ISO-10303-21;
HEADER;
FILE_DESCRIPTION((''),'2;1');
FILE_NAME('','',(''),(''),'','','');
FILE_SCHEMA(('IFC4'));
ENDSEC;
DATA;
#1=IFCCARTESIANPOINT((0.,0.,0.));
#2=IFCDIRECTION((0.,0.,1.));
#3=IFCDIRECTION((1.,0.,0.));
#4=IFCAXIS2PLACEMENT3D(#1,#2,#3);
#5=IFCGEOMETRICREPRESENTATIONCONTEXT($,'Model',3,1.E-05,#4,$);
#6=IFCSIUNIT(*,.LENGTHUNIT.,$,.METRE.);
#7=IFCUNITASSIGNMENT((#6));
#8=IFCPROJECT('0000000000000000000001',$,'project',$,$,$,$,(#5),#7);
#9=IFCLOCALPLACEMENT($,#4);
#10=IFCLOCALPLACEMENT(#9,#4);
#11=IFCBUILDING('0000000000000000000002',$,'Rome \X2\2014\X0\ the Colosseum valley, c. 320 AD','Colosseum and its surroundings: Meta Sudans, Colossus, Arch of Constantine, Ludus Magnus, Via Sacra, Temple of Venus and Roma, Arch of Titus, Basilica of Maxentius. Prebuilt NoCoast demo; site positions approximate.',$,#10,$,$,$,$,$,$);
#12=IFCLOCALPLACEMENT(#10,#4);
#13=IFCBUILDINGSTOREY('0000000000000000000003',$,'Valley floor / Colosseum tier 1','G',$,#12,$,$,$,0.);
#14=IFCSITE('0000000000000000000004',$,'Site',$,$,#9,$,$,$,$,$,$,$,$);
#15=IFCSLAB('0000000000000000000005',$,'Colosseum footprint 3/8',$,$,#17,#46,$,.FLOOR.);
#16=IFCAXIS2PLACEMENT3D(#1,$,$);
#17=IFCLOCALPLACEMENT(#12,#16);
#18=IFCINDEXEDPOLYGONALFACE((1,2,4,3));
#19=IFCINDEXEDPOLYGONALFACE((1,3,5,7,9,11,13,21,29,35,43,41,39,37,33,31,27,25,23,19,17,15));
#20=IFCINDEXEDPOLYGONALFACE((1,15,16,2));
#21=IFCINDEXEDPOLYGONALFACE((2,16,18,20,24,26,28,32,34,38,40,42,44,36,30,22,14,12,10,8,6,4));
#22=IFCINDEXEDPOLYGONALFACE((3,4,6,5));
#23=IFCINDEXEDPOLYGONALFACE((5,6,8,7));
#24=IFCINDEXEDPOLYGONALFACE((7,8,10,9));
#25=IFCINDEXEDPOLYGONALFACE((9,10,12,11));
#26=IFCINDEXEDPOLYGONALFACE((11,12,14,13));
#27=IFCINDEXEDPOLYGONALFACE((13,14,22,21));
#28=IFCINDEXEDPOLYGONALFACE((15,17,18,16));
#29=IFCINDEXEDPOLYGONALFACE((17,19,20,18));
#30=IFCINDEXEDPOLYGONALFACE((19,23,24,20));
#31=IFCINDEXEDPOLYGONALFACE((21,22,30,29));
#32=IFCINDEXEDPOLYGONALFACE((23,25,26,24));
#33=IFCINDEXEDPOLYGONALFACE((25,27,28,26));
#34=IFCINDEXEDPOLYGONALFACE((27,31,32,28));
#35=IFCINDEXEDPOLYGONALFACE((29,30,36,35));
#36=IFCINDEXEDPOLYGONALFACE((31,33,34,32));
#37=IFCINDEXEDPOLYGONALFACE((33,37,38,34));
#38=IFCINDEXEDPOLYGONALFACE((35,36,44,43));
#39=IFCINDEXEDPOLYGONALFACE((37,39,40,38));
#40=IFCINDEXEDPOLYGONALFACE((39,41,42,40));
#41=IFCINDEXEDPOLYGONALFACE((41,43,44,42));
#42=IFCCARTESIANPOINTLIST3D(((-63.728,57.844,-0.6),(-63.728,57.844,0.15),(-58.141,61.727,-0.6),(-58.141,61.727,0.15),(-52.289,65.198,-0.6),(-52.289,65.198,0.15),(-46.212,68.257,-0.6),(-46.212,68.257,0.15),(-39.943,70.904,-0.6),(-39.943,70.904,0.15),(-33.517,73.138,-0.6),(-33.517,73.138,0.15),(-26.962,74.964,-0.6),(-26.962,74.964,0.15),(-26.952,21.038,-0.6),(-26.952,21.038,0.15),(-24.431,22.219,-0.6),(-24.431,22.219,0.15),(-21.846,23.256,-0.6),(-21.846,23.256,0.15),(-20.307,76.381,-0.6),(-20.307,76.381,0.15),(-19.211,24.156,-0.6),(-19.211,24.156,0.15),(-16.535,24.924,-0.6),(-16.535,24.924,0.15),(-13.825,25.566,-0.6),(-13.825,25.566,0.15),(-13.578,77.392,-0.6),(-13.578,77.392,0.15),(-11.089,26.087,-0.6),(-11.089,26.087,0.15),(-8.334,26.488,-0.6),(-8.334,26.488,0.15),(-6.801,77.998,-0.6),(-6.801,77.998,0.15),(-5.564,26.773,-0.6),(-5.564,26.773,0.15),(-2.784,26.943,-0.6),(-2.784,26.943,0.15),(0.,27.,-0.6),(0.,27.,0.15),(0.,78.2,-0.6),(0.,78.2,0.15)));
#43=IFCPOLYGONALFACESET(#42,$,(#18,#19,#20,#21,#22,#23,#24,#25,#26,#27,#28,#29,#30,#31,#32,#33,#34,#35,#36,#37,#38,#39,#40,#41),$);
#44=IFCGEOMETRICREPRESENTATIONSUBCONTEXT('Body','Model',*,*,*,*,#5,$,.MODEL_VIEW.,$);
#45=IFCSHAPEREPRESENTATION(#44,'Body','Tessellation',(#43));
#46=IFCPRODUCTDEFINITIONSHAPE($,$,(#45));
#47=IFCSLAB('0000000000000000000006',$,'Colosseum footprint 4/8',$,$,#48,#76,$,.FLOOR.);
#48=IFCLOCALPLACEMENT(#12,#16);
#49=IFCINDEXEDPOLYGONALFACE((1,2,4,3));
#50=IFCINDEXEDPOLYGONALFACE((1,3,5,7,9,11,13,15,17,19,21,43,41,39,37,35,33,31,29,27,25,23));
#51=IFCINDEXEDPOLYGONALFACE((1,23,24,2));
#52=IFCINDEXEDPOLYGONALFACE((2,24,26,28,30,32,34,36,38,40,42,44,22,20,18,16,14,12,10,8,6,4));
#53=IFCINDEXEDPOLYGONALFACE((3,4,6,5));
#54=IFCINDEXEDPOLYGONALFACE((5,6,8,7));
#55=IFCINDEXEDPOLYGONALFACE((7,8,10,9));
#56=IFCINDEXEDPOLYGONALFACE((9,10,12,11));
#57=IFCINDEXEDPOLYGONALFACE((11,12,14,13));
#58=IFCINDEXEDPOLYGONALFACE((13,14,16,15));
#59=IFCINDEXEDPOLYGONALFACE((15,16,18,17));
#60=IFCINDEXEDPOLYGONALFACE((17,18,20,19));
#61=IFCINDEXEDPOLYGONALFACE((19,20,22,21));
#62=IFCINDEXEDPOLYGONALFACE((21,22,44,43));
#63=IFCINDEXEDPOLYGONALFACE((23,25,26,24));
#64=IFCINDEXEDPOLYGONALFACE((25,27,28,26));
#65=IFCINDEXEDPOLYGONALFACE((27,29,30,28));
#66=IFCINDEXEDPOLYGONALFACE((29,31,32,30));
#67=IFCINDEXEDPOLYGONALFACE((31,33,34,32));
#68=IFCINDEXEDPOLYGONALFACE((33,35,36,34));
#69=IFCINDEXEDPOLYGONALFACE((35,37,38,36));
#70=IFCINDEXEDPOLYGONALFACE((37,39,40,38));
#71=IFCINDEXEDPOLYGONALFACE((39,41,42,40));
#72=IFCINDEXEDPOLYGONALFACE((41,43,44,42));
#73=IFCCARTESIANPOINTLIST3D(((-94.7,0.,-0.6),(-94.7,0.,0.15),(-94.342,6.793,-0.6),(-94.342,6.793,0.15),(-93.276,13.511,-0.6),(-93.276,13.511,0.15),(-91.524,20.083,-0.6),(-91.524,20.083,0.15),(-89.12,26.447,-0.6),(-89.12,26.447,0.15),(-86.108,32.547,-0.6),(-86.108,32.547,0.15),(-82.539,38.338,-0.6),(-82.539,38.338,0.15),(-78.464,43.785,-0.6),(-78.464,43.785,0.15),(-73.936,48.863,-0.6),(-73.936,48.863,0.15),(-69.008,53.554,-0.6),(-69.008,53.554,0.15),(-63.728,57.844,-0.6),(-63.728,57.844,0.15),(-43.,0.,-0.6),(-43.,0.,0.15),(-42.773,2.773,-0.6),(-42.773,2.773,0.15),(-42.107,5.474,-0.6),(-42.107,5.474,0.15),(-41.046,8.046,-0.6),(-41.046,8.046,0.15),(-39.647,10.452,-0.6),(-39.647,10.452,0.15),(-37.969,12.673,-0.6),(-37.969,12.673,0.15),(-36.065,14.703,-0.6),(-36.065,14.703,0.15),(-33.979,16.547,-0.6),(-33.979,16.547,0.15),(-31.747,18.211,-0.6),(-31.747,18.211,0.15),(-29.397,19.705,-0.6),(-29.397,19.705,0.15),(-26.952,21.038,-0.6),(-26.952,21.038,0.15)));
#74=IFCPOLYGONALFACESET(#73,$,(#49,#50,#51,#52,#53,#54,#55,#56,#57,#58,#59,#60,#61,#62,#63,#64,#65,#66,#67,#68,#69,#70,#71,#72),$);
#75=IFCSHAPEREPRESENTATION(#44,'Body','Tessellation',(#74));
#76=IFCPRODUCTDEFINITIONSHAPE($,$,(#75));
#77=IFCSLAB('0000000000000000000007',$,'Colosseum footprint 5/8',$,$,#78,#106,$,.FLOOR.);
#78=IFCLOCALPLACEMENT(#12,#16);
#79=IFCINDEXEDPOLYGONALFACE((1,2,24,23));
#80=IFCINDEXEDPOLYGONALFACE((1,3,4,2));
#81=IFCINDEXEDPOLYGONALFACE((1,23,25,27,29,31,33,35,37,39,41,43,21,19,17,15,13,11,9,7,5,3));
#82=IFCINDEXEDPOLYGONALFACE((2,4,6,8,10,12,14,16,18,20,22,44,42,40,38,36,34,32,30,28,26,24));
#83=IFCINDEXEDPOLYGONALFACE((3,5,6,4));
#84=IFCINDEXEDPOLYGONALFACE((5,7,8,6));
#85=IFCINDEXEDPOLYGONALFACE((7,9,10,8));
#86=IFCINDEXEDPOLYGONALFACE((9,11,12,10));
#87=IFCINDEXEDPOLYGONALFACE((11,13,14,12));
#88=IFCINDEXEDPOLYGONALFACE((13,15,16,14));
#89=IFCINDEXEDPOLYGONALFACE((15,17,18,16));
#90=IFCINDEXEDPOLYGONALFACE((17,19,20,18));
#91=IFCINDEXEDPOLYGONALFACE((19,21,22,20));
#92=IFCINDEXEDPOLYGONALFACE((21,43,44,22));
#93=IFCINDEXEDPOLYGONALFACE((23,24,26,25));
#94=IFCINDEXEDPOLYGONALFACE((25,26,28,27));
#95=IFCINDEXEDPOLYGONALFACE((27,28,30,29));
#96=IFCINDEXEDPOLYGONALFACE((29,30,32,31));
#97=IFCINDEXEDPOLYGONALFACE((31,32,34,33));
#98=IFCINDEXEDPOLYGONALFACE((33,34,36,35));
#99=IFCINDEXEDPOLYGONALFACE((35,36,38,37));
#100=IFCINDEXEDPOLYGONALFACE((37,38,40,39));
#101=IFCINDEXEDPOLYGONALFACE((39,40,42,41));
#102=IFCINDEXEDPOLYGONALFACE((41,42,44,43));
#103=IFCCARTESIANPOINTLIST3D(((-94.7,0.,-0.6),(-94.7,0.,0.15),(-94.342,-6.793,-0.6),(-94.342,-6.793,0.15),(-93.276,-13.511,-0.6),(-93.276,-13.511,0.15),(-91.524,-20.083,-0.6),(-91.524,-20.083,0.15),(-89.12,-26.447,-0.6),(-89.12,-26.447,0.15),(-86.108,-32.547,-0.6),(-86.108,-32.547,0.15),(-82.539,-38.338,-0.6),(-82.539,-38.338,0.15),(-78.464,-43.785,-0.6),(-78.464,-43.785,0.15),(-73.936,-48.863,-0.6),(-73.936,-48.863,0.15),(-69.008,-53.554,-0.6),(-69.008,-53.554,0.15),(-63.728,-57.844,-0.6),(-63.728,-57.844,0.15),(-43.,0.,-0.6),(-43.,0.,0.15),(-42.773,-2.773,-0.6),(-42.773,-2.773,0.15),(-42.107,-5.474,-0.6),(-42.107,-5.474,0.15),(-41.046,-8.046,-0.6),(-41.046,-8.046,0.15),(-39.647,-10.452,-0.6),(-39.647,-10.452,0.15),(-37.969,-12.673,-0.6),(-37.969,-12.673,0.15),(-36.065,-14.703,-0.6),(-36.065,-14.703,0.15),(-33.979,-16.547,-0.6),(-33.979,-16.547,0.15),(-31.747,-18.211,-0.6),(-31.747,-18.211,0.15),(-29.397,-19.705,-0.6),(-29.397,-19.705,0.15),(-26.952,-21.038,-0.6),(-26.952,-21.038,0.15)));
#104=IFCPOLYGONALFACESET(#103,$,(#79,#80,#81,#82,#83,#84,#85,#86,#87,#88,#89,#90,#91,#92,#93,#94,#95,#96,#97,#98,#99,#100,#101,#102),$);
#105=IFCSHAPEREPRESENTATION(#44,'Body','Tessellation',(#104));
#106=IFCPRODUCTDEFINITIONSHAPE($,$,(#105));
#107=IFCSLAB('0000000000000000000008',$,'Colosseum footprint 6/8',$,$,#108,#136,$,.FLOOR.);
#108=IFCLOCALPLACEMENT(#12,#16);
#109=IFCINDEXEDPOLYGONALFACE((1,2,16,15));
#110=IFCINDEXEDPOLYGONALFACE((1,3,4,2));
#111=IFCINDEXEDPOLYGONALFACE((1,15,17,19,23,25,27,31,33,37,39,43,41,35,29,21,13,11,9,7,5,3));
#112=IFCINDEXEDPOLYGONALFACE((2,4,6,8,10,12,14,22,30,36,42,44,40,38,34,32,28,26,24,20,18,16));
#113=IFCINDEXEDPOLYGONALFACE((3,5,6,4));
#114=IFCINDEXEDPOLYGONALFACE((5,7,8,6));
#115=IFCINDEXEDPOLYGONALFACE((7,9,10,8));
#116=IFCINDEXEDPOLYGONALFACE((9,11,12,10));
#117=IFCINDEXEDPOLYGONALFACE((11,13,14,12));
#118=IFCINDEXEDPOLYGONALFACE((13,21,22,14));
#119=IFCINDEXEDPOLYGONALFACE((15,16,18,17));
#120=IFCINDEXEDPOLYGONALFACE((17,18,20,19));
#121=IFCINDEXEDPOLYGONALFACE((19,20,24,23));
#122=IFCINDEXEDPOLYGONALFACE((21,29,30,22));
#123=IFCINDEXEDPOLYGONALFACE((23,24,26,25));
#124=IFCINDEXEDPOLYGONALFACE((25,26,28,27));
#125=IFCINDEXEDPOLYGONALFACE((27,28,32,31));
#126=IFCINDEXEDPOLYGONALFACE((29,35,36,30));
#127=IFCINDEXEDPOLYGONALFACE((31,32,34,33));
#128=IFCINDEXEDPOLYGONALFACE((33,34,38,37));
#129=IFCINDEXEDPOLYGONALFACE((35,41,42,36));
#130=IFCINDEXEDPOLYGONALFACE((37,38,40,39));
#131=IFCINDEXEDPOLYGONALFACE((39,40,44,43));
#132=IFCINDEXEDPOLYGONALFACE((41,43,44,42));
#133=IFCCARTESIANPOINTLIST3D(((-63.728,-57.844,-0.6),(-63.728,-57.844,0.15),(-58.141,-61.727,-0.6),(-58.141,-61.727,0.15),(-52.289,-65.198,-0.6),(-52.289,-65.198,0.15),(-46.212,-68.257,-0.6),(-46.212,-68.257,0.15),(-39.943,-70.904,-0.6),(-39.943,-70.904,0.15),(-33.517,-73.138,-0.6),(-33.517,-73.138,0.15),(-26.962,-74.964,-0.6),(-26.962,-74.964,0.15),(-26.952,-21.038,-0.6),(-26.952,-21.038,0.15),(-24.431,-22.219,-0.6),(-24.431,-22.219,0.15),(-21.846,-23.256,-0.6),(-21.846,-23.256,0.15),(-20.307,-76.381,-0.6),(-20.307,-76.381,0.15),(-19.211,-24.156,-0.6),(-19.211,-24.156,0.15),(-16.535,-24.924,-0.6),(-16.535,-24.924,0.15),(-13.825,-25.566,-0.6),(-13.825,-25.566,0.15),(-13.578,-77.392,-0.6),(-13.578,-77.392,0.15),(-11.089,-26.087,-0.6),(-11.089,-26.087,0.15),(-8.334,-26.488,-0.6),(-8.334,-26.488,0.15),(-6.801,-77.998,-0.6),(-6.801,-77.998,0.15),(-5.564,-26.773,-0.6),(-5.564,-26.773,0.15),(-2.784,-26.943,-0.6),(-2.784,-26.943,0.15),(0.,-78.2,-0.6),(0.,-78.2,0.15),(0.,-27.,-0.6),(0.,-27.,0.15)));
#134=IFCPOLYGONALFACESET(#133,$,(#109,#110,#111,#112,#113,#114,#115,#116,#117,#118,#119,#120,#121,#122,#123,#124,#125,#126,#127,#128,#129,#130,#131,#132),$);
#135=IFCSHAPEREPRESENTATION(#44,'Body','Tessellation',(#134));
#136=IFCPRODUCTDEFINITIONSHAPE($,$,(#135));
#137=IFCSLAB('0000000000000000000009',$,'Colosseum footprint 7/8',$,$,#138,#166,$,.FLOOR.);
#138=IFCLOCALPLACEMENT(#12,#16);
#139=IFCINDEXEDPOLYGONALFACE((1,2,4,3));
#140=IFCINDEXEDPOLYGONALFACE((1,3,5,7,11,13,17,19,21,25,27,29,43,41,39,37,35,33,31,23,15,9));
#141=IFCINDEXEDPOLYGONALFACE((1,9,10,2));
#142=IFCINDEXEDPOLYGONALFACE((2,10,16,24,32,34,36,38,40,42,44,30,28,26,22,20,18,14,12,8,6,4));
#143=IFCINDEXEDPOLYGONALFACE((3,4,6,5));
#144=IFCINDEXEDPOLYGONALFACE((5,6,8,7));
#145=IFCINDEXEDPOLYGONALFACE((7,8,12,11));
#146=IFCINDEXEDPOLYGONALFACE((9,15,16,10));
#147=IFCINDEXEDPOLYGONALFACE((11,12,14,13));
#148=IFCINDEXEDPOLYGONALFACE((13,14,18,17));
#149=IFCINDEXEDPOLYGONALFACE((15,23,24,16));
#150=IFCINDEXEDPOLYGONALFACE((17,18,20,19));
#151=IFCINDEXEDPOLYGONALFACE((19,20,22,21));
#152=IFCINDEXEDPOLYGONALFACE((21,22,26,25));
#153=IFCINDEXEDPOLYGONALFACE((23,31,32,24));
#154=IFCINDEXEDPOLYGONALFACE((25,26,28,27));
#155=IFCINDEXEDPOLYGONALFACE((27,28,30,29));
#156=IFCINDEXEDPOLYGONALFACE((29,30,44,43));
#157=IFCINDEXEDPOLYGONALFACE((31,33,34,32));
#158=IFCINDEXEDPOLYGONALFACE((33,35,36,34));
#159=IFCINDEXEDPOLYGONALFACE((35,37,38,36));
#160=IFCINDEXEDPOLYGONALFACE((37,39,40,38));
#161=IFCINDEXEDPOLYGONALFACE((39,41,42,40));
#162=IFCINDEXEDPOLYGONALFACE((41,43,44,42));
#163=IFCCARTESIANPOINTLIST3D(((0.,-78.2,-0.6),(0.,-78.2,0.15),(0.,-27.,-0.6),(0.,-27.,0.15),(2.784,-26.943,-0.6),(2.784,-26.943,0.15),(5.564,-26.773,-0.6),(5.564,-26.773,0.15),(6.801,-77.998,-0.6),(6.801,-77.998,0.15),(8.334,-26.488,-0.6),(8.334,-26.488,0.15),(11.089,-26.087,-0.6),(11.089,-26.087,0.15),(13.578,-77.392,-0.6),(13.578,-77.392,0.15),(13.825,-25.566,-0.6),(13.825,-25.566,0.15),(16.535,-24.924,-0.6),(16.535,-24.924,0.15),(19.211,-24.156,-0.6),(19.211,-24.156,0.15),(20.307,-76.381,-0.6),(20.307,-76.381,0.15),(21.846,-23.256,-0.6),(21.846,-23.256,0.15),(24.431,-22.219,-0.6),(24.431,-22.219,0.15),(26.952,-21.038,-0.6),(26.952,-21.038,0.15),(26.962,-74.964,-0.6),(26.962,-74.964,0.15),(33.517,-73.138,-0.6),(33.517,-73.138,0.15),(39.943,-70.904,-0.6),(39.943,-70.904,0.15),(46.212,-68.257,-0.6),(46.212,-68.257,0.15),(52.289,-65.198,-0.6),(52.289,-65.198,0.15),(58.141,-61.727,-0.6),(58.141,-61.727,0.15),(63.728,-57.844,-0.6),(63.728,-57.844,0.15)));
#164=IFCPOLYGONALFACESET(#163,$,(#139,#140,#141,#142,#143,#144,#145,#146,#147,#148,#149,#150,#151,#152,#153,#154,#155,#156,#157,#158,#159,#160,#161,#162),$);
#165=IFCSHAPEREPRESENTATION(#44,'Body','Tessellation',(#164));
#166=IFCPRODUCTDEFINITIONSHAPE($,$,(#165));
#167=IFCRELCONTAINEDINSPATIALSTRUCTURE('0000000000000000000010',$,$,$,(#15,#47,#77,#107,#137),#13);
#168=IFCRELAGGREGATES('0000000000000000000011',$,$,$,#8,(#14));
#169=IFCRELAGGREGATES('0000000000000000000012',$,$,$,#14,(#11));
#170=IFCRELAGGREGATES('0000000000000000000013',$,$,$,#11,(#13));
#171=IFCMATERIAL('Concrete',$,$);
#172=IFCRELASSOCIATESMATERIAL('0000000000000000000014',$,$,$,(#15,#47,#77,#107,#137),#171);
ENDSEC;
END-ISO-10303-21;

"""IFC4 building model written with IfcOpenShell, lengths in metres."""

from ifc_helpers import new_model, si_unit, frame, origin_with_axes, place, context, subcontext, project, spatial, indexed_curve, outline, extrude, material, element, save


model = new_model("IFC4")

# Units and contexts
model_context = context("Model", 3, precision=1e-05, world=origin_with_axes())
body_context = subcontext(model_context, "Body", "Model", "MODEL_VIEW")
ifc_project = project(units=[si_unit("LENGTHUNIT", "METRE")], contexts=[model_context])

# Site, building, storey
site_placement = place(None, origin_with_axes())
site = spatial("IfcSite", under=ifc_project, at=site_placement, Name="Site")
building_placement = place(site_placement, origin_with_axes())
building = spatial("IfcBuilding", under=site, at=building_placement, Name="Rome — the Colosseum valley, c. 320 AD", Description="Colosseum and its surroundings: Meta Sudans, Colossus, Arch of Constantine, Ludus Magnus, Via Sacra, Temple of Venus and Roma, Arch of Titus, Basilica of Maxentius. Prebuilt NoCoast demo; site positions approximate.")
storey_placement = place(building_placement, origin_with_axes())
storey = spatial("IfcBuildingStorey", under=building, at=storey_placement, Name="Valley floor / Colosseum tier 1", Description="G", Elevation=0.0)

# Slabs
ifc_material_1 = material(Name="Concrete")
slab_1_placement = place(storey_placement, frame((0.0, 0.0, -0.6), z_axis=(0.0, 0.0, 1.0), x_axis=(1.0, 0.0, 0.0)))
element("IfcSlab", 1, at=slab_1_placement, inside=storey, material=ifc_material_1, Name="Colosseum footprint 3/8", PredefinedType="FLOOR", context=body_context, shape_type="SweptSolid", body=[
    extrude(outline(indexed_curve([(0.0, 27.0), (-2.784, 26.943), (-5.564, 26.773), (-8.334, 26.488), (-11.089, 26.087), (-13.825, 25.566), (-16.535, 24.924), (-19.211, 24.156), (-21.846, 23.256), (-24.431, 22.219), (-26.952, 21.038), (-63.728, 57.844), (-58.141, 61.727), (-52.289, 65.198), (-46.212, 68.257), (-39.943, 70.904), (-33.517, 73.138), (-26.962, 74.964), (-20.307, 76.381), (-13.578, 77.392), (-6.801, 77.998), (0.0, 78.2)])), None, (0.0, 0.0, 1.0), 0.75),
])
slab_2_placement = place(storey_placement, frame((0.0, 0.0, -0.6), z_axis=(0.0, 0.0, 1.0), x_axis=(1.0, 0.0, 0.0)))
element("IfcSlab", 2, at=slab_2_placement, inside=storey, material=ifc_material_1, Name="Colosseum footprint 4/8", PredefinedType="FLOOR", context=body_context, shape_type="SweptSolid", body=[
    extrude(outline(indexed_curve([(-26.952, 21.038), (-29.397, 19.705), (-31.747, 18.211), (-33.979, 16.547), (-36.065, 14.703), (-37.969, 12.673), (-39.647, 10.452), (-41.046, 8.046), (-42.107, 5.474), (-42.773, 2.773), (-43.0, 0.0), (-94.7, 0.0), (-94.342, 6.793), (-93.276, 13.511), (-91.524, 20.083), (-89.12, 26.447), (-86.108, 32.547), (-82.539, 38.338), (-78.464, 43.785), (-73.936, 48.863), (-69.008, 53.554), (-63.728, 57.844)])), None, (0.0, 0.0, 1.0), 0.75),
])
slab_3_placement = place(storey_placement, frame((0.0, 0.0, -0.6), z_axis=(0.0, 0.0, 1.0), x_axis=(1.0, 0.0, 0.0)))
element("IfcSlab", 3, at=slab_3_placement, inside=storey, material=ifc_material_1, Name="Colosseum footprint 5/8", PredefinedType="FLOOR", context=body_context, shape_type="SweptSolid", body=[
    extrude(outline(indexed_curve([(-43.0, 0.0), (-42.773, -2.773), (-42.107, -5.474), (-41.046, -8.046), (-39.647, -10.452), (-37.969, -12.673), (-36.065, -14.703), (-33.979, -16.547), (-31.747, -18.211), (-29.397, -19.705), (-26.952, -21.038), (-63.728, -57.844), (-69.008, -53.554), (-73.936, -48.863), (-78.464, -43.785), (-82.539, -38.338), (-86.108, -32.547), (-89.12, -26.447), (-91.524, -20.083), (-93.276, -13.511), (-94.342, -6.793), (-94.7, 0.0)])), None, (0.0, 0.0, 1.0), 0.75),
])
slab_4_placement = place(storey_placement, frame((0.0, 0.0, -0.6), z_axis=(0.0, 0.0, 1.0), x_axis=(1.0, 0.0, 0.0)))
element("IfcSlab", 4, at=slab_4_placement, inside=storey, material=ifc_material_1, Name="Colosseum footprint 6/8", PredefinedType="FLOOR", context=body_context, shape_type="SweptSolid", body=[
    extrude(outline(indexed_curve([(-26.952, -21.038), (-24.431, -22.219), (-21.846, -23.256), (-19.211, -24.156), (-16.535, -24.924), (-13.825, -25.566), (-11.089, -26.087), (-8.334, -26.488), (-5.564, -26.773), (-2.784, -26.943), (0.0, -27.0), (0.0, -78.2), (-6.801, -77.998), (-13.578, -77.392), (-20.307, -76.381), (-26.962, -74.964), (-33.517, -73.138), (-39.943, -70.904), (-46.212, -68.257), (-52.289, -65.198), (-58.141, -61.727), (-63.728, -57.844)])), None, (0.0, 0.0, 1.0), 0.75),
])
slab_5_placement = place(storey_placement, frame((0.0, 0.0, -0.6), z_axis=(0.0, 0.0, 1.0), x_axis=(1.0, 0.0, 0.0)))
element("IfcSlab", 5, at=slab_5_placement, inside=storey, material=ifc_material_1, Name="Colosseum footprint 7/8", PredefinedType="FLOOR", context=body_context, shape_type="SweptSolid", body=[
    extrude(outline(indexed_curve([(0.0, -27.0), (2.784, -26.943), (5.564, -26.773), (8.334, -26.488), (11.089, -26.087), (13.825, -25.566), (16.535, -24.924), (19.211, -24.156), (21.846, -23.256), (24.431, -22.219), (26.952, -21.038), (63.728, -57.844), (58.141, -61.727), (52.289, -65.198), (46.212, -68.257), (39.943, -70.904), (33.517, -73.138), (26.962, -74.964), (20.307, -76.381), (13.578, -77.392), (6.801, -77.998), (0.0, -78.2)])), None, (0.0, 0.0, 1.0), 0.75),
])

save(model, "model.ifc")
